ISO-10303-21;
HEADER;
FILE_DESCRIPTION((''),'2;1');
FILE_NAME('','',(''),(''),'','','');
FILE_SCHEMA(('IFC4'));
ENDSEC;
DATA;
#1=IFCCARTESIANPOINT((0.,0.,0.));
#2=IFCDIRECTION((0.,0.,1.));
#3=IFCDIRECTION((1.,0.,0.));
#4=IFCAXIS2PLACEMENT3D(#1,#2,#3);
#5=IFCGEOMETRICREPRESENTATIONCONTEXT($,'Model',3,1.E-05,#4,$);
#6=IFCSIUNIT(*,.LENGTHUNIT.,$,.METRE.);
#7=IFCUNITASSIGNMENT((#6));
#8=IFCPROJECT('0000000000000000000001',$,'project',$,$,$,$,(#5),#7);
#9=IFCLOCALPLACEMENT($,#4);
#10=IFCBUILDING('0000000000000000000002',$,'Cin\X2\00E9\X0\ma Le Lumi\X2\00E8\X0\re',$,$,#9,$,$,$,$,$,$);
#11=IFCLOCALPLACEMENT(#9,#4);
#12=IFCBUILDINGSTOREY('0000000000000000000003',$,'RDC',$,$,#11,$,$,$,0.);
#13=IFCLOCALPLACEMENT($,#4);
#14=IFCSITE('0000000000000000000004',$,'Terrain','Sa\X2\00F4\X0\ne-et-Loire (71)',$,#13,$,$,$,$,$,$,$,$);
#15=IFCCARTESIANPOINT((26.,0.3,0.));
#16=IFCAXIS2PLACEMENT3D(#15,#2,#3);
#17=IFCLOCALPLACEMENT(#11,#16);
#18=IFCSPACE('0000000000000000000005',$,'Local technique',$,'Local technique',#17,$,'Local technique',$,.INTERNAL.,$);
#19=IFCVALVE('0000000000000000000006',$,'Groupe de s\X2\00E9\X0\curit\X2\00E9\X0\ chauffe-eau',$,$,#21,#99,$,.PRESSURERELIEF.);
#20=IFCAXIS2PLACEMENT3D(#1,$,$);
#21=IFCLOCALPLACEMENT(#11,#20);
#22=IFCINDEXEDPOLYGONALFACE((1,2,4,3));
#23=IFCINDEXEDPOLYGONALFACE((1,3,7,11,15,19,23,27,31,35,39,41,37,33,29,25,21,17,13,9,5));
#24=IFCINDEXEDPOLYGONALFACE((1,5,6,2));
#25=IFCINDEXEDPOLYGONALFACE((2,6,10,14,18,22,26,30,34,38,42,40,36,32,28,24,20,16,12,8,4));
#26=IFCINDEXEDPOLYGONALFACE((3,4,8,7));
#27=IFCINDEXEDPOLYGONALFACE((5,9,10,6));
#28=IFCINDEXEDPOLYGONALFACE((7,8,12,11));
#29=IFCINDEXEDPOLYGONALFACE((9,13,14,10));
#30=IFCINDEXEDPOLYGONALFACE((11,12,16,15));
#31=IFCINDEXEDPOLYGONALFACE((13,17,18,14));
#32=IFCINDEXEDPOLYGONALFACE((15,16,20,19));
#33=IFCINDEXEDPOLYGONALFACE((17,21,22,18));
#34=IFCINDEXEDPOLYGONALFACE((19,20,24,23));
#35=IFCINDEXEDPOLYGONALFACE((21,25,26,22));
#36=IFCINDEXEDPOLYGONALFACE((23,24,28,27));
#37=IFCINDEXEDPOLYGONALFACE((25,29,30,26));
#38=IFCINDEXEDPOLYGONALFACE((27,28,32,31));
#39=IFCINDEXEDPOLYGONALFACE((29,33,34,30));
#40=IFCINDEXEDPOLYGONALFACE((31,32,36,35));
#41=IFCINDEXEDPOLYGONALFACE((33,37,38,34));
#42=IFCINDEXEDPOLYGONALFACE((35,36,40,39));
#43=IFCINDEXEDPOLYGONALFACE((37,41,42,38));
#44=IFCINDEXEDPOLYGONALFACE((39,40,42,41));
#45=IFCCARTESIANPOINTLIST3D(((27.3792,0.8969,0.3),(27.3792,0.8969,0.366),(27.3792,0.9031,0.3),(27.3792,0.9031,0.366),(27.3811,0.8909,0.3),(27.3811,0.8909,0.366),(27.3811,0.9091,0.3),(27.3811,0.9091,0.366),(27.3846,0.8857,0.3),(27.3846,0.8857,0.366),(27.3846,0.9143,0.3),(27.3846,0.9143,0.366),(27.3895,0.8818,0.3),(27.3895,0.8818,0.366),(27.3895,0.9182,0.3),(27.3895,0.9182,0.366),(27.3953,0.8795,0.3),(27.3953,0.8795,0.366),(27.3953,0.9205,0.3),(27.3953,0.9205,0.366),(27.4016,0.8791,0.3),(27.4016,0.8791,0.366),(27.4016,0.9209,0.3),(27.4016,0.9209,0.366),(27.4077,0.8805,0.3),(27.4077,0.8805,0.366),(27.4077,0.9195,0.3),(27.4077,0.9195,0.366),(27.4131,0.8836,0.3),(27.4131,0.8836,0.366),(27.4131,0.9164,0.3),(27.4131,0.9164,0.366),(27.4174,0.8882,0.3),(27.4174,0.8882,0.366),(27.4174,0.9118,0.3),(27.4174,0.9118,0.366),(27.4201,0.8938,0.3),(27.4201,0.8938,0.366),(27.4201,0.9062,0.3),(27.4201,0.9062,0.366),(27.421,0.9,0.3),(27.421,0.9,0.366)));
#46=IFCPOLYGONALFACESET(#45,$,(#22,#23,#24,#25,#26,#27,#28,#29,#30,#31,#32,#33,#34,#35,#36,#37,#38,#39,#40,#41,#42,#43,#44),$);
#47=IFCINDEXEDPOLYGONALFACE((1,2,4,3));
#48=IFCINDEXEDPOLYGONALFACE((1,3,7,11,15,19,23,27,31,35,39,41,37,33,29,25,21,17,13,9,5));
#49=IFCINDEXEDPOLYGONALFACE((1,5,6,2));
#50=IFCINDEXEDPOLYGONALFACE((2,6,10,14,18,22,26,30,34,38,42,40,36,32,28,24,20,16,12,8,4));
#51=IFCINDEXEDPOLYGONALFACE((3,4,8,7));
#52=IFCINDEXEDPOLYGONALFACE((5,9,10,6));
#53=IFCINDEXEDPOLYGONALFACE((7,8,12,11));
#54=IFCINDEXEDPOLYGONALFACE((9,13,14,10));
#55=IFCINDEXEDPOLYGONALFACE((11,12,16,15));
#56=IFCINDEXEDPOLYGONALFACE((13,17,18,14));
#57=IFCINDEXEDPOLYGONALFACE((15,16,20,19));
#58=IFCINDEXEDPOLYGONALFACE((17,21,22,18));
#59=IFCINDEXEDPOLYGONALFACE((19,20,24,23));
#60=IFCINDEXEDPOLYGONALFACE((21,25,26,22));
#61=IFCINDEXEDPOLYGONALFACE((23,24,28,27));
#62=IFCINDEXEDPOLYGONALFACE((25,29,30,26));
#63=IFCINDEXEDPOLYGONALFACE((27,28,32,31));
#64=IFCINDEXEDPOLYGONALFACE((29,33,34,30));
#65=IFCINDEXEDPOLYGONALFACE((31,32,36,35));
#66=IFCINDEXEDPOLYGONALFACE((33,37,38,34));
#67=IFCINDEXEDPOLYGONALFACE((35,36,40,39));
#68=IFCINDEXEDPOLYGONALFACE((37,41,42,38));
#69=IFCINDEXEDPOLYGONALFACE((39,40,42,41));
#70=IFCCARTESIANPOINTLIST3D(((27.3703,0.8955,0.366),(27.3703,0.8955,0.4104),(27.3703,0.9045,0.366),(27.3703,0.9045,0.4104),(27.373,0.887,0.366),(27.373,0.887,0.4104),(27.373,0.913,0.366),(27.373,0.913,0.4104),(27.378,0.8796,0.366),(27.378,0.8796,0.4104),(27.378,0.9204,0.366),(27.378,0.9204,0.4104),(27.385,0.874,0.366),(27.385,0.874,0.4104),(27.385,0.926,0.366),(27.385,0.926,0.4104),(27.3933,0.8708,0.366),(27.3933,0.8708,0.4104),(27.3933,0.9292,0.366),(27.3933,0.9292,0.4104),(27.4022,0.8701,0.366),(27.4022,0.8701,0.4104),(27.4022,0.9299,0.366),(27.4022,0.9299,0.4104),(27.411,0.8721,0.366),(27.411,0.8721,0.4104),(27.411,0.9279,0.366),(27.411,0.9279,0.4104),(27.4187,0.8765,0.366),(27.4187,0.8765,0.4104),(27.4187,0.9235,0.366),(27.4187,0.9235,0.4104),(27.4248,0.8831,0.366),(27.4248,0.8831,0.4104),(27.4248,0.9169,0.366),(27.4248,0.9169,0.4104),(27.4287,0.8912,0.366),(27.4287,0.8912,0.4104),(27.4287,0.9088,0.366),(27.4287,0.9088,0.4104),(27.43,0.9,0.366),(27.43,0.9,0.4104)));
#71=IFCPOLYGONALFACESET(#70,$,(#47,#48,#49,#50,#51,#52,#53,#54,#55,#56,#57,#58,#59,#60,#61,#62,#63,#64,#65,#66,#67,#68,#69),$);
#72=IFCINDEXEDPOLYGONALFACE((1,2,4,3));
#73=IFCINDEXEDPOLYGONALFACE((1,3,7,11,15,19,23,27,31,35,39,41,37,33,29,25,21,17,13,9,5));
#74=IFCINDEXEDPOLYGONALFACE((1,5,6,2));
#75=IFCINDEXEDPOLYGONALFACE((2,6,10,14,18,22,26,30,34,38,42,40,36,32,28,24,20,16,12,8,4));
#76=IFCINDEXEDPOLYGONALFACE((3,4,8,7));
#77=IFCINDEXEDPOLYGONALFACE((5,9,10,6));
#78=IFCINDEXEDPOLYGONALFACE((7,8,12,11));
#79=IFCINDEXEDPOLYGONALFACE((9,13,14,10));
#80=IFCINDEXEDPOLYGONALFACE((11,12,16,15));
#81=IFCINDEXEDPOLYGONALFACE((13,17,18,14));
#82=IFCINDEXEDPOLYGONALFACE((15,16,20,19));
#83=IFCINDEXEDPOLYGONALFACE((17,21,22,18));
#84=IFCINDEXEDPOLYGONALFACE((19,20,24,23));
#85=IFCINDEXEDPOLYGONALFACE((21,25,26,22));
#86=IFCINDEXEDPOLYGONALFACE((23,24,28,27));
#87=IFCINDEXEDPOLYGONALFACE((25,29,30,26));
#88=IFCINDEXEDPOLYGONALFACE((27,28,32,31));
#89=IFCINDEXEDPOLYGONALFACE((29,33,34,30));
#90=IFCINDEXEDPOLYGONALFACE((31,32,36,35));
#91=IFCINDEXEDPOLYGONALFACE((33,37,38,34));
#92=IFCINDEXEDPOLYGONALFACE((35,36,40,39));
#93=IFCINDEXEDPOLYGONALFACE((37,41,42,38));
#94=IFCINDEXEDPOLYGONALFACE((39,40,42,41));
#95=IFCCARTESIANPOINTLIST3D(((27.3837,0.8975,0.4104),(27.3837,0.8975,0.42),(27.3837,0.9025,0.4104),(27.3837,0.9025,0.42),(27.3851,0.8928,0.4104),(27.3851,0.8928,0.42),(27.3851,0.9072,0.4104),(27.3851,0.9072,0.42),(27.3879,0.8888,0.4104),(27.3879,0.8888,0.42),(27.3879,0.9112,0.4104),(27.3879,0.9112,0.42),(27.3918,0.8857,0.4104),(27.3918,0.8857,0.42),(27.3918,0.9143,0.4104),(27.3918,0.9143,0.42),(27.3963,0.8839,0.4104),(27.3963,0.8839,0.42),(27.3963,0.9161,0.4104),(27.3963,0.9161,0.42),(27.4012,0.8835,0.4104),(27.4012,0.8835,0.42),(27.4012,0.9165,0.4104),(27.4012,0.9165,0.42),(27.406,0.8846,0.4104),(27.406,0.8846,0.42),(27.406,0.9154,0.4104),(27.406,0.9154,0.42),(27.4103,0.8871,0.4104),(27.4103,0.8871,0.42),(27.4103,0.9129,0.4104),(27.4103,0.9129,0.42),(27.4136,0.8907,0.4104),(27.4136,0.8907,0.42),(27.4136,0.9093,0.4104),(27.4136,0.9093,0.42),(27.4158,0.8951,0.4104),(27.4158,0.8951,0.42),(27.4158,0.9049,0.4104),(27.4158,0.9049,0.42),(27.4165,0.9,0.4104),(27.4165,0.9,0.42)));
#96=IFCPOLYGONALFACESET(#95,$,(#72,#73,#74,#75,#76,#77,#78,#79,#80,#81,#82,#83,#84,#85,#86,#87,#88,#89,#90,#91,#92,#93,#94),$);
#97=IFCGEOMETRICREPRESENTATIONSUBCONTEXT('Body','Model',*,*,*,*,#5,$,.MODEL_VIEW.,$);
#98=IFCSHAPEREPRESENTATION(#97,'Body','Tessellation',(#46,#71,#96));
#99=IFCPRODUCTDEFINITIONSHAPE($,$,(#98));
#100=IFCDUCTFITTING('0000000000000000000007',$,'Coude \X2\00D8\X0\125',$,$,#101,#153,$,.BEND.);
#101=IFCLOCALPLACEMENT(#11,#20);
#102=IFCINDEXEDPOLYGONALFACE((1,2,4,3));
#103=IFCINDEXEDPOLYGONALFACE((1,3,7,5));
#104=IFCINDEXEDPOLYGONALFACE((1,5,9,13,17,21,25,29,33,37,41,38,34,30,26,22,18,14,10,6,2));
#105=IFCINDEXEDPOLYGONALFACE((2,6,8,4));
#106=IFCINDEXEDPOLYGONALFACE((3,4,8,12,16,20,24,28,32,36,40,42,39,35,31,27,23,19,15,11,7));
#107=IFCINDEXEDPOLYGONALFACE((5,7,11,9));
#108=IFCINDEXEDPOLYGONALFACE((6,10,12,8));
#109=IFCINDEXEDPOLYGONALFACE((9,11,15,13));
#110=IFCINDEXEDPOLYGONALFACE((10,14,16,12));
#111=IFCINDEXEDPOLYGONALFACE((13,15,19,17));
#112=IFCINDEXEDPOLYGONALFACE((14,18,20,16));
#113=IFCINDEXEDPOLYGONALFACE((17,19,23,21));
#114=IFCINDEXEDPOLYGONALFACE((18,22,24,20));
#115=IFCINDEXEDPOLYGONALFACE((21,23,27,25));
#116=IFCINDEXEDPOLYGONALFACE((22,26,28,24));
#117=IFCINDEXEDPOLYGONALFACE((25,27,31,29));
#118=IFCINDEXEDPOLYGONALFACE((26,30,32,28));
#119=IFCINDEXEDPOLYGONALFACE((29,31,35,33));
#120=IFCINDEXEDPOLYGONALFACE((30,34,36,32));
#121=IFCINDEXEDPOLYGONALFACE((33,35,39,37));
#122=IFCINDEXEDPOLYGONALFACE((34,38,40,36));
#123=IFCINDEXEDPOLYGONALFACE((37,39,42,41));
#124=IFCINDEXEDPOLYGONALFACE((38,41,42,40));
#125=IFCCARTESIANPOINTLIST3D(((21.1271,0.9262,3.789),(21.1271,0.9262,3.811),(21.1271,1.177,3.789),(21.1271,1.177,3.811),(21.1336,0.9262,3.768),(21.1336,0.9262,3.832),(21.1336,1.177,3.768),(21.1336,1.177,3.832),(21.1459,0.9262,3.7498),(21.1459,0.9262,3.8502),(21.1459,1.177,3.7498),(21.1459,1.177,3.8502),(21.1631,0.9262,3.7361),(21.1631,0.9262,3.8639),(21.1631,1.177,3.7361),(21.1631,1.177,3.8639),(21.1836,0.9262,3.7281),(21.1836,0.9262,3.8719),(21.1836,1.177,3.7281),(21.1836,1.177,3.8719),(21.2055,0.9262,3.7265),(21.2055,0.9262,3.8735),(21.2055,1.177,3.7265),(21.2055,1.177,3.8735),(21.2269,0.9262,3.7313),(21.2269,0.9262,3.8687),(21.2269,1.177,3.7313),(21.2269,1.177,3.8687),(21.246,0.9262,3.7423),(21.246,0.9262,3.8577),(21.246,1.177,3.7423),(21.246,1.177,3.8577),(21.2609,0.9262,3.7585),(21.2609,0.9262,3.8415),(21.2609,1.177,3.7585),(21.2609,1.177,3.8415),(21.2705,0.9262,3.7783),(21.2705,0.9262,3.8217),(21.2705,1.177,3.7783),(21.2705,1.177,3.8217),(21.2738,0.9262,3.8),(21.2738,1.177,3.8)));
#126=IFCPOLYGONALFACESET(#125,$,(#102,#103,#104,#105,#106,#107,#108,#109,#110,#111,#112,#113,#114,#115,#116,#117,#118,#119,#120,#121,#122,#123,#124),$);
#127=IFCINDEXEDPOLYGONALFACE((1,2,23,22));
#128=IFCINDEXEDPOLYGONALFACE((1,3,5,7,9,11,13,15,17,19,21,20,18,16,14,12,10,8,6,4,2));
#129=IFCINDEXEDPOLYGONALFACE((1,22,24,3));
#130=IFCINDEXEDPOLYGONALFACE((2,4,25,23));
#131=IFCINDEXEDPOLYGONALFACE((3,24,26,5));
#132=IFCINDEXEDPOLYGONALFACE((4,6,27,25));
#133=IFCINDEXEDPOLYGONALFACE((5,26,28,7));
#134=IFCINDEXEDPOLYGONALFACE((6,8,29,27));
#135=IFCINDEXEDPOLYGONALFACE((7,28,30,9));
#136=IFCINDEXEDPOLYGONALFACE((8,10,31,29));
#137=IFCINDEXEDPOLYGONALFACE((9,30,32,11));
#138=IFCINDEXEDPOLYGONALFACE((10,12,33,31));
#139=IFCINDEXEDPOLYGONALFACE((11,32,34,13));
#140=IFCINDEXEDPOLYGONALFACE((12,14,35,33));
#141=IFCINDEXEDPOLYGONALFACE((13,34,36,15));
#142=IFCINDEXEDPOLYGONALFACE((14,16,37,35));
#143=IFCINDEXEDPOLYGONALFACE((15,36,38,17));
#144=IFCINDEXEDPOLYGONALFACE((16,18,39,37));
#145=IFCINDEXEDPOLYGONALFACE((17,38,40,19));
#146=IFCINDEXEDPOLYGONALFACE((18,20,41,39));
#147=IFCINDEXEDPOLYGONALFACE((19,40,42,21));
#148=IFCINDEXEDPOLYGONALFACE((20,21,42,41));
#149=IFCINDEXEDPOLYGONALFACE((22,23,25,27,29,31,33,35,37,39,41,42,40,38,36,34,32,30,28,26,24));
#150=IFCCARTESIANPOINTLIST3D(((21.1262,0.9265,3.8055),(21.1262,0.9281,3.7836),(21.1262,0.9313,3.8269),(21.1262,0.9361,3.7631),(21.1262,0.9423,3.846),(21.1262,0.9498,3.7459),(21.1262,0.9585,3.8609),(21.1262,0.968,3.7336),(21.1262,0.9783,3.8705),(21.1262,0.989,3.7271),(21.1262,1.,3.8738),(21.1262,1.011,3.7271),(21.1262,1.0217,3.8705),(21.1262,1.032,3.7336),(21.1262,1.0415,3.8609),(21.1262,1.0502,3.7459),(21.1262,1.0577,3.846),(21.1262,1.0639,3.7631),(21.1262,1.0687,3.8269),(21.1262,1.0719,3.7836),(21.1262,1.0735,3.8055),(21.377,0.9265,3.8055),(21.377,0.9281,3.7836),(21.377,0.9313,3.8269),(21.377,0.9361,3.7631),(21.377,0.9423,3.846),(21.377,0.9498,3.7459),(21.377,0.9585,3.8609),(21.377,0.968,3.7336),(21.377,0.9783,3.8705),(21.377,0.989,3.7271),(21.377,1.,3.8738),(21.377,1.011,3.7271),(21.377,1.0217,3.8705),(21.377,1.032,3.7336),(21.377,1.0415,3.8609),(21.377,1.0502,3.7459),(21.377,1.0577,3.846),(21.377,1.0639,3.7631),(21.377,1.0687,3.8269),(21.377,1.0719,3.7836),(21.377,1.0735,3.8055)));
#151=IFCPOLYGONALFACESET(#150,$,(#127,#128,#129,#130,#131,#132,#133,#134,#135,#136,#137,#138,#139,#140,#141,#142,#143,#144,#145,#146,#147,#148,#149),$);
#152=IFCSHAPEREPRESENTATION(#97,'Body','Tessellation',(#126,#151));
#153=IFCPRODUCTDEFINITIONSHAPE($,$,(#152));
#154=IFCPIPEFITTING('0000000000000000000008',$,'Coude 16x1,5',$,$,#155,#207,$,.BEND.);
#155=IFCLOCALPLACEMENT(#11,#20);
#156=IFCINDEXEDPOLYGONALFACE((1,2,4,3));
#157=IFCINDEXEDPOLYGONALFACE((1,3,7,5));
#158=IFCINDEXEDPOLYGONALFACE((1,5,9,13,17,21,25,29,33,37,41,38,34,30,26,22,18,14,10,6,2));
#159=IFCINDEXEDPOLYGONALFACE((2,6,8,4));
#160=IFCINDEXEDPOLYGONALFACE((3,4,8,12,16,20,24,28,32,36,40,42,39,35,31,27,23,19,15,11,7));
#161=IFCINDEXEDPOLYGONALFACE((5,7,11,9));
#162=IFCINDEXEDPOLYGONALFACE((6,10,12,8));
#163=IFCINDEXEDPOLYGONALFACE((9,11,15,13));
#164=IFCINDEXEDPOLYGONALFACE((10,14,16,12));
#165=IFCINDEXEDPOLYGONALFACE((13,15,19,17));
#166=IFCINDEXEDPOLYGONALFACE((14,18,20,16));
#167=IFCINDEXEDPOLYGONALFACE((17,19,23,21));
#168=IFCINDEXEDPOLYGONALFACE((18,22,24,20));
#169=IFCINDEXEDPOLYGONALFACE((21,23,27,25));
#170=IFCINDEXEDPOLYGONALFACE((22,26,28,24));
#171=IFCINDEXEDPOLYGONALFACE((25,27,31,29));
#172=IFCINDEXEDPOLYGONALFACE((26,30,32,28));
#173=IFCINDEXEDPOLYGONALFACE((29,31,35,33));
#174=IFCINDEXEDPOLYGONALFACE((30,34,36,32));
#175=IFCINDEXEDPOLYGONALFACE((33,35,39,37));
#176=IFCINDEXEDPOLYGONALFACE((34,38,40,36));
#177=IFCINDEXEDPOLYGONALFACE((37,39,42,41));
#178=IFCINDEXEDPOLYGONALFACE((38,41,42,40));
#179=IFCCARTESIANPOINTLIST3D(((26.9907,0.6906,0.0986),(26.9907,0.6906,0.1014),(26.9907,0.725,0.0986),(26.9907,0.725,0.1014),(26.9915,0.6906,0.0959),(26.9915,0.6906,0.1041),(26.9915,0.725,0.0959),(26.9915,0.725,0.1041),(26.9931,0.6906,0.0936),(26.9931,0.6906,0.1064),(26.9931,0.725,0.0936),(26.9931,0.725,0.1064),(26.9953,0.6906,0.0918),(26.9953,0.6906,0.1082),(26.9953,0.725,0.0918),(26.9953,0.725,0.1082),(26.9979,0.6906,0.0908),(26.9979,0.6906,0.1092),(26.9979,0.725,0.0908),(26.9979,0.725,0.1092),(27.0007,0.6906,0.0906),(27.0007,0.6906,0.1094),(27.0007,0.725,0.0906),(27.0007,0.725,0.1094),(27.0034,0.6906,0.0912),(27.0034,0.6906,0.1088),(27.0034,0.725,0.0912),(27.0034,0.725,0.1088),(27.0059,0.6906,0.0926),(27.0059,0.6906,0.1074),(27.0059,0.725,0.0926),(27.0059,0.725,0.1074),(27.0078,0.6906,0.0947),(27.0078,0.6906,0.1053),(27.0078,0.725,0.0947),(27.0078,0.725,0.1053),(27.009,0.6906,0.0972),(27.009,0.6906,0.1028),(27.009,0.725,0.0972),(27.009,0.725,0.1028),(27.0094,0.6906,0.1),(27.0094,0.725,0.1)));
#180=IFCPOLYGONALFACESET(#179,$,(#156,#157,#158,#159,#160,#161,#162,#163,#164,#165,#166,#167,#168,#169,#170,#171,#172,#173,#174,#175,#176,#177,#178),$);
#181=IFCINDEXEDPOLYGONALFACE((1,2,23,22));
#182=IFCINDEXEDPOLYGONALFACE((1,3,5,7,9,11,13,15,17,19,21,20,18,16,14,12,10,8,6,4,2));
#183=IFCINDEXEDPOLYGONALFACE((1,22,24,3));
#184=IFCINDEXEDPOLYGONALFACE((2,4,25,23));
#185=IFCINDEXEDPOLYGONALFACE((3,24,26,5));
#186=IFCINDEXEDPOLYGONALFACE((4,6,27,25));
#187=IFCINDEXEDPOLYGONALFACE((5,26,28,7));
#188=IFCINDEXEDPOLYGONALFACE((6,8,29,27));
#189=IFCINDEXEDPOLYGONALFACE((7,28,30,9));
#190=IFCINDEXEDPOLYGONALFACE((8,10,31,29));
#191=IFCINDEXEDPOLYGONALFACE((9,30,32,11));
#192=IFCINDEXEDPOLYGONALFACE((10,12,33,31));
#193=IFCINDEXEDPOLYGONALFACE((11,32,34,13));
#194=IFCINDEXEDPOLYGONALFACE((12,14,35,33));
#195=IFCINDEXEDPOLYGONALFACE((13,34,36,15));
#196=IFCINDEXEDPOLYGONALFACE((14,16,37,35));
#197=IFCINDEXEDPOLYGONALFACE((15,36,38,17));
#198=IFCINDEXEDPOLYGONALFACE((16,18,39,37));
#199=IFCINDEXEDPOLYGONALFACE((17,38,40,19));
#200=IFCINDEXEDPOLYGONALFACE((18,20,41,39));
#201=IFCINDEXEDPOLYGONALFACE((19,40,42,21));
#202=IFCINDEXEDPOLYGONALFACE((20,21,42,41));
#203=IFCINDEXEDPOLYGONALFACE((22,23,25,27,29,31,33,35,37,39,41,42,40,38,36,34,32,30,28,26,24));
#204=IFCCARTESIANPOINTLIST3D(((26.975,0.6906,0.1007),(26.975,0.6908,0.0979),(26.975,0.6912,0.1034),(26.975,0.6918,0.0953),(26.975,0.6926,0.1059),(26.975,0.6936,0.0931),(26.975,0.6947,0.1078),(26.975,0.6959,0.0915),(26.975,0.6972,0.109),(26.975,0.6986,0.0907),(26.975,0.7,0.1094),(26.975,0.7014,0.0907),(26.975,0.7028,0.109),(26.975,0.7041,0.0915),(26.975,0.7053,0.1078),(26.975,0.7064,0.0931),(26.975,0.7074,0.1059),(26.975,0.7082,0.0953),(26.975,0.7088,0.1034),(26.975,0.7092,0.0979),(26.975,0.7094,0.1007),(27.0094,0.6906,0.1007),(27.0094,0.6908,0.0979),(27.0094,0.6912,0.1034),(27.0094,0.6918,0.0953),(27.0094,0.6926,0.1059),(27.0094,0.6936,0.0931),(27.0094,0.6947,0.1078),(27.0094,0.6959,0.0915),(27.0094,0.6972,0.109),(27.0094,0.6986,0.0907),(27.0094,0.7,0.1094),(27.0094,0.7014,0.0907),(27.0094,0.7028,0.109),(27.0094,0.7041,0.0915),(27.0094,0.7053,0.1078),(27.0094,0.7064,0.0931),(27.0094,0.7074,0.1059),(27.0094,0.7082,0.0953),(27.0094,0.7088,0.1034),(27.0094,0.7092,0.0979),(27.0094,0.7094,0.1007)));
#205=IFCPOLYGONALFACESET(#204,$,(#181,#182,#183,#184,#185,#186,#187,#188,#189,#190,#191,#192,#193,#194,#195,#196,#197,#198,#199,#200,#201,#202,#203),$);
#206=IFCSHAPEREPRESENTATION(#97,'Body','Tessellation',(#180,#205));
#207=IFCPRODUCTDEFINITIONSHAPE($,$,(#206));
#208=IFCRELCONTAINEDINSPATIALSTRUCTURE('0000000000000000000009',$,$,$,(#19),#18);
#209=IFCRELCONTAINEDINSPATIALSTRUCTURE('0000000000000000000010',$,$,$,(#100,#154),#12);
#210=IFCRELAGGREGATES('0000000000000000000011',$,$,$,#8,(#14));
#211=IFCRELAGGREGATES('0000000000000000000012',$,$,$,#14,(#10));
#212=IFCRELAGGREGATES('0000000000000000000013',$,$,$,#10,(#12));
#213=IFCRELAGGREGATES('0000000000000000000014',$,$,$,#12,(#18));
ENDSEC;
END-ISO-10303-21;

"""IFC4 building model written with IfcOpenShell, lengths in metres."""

from ifc_helpers import new_model, si_unit, frame, origin_with_axes, place, context, subcontext, project, spatial, circle, extrude, element, save


model = new_model("IFC4")

# Units and contexts
model_context = context("Model", 3, precision=1e-05, world=origin_with_axes())
body_context = subcontext(model_context, "Body", "Model", "MODEL_VIEW")
ifc_project = project(units=[si_unit("LENGTHUNIT", "METRE")], contexts=[model_context])

# Site, building, storey
site_placement = place(None, origin_with_axes())
site = spatial("IfcSite", under=ifc_project, at=site_placement, Name="Terrain", Description="Saône-et-Loire (71)")
building_placement = place(None, origin_with_axes())
building = spatial("IfcBuilding", under=site, at=building_placement, Name="Cinéma Le Lumière")
storey_placement = place(building_placement, origin_with_axes())
storey = spatial("IfcBuildingStorey", under=building, at=storey_placement, Name="RDC", Elevation=0.0)

# Shared definitions
space_1_placement = place(storey_placement, frame((26.0, 0.3, 0.0), z_axis=(0.0, 0.0, 1.0), x_axis=(1.0, 0.0, 0.0)))
space_1 = spatial("IfcSpace", under=storey, at=space_1_placement, Name="Local technique", ObjectType="Local technique", LongName="Local technique", PredefinedType="INTERNAL")

# Valve
valve_placement = place(space_1_placement, frame((1.4, 0.6, 0.3), z_axis=(0.0, 0.0, 1.0), x_axis=(1.0, 0.0, 0.0)))
element("IfcValve", 1, at=valve_placement, inside=space_1, Name="Groupe de sécurité chauffe-eau", PredefinedType="PRESSURERELIEF", context=body_context, shape_type="SweptSolid", body=[
    extrude(circle(Radius=0.021), origin_with_axes(), (0.0, 0.0, 1.0), 0.066),
    extrude(circle(Radius=0.03), frame((0.0, 0.0, 0.066), z_axis=(0.0, 0.0, 1.0), x_axis=(1.0, 0.0, 0.0)), (0.0, 0.0, 1.0), 0.0444),
    extrude(circle(Radius=0.0165), frame((0.0, 0.0, 0.1104), z_axis=(0.0, 0.0, 1.0), x_axis=(1.0, 0.0, 0.0)), (0.0, 0.0, 1.0), 0.0096),
])

# Duct fitting
duct_fitting_placement = place(storey_placement, frame((21.2, 1.0, 3.8), z_axis=(0.0, 0.0, 1.0), x_axis=(1.0, 0.0, 0.0)))
element("IfcDuctFitting", 2, at=duct_fitting_placement, inside=storey, Name="Coude Ø125", PredefinedType="BEND", context=body_context, shape_type="SweptSolid", body=[
    extrude(circle(Radius=0.0737), frame((0.0, -0.0737, 0.0), z_axis=(0.0, 1.0, 0.0), x_axis=(1.0, 0.0, 0.0)), (0.0, 0.0, 1.0), 0.2507),
    extrude(circle(Radius=0.0737), frame((-0.0737, 0.0, 0.0), z_axis=(1.0, 0.0, 0.0), x_axis=(0.0, 0.0, 1.0)), (0.0, 0.0, 1.0), 0.2507),
])

# Pipe fitting
for number, where, z_axis, x_axis, name in (
    (3, (27.0, 0.7, 0.1), (0.0, 0.0, 1.0), (1.0, 0.0, 0.0), "Coude 16x1,5"),
):
    element("IfcPipeFitting", number, at=place(storey_placement, frame(where, z_axis=z_axis, x_axis=x_axis)), inside=storey, Name=name, PredefinedType="BEND", context=body_context, shape_type="SweptSolid", body=[
        extrude(circle(Radius=0.0094), frame((0.0, -0.0094, 0.0), z_axis=(0.0, 1.0, 0.0), x_axis=(1.0, 0.0, 0.0)), (0.0, 0.0, 1.0), 0.0344),
        extrude(circle(Radius=0.0094), frame((0.0094, 0.0, 0.0), z_axis=(-1.0, 0.0, 0.0), x_axis=(0.0, 0.0, 1.0)), (0.0, 0.0, 1.0), 0.0344),
    ])

save(model, "model.ifc")
